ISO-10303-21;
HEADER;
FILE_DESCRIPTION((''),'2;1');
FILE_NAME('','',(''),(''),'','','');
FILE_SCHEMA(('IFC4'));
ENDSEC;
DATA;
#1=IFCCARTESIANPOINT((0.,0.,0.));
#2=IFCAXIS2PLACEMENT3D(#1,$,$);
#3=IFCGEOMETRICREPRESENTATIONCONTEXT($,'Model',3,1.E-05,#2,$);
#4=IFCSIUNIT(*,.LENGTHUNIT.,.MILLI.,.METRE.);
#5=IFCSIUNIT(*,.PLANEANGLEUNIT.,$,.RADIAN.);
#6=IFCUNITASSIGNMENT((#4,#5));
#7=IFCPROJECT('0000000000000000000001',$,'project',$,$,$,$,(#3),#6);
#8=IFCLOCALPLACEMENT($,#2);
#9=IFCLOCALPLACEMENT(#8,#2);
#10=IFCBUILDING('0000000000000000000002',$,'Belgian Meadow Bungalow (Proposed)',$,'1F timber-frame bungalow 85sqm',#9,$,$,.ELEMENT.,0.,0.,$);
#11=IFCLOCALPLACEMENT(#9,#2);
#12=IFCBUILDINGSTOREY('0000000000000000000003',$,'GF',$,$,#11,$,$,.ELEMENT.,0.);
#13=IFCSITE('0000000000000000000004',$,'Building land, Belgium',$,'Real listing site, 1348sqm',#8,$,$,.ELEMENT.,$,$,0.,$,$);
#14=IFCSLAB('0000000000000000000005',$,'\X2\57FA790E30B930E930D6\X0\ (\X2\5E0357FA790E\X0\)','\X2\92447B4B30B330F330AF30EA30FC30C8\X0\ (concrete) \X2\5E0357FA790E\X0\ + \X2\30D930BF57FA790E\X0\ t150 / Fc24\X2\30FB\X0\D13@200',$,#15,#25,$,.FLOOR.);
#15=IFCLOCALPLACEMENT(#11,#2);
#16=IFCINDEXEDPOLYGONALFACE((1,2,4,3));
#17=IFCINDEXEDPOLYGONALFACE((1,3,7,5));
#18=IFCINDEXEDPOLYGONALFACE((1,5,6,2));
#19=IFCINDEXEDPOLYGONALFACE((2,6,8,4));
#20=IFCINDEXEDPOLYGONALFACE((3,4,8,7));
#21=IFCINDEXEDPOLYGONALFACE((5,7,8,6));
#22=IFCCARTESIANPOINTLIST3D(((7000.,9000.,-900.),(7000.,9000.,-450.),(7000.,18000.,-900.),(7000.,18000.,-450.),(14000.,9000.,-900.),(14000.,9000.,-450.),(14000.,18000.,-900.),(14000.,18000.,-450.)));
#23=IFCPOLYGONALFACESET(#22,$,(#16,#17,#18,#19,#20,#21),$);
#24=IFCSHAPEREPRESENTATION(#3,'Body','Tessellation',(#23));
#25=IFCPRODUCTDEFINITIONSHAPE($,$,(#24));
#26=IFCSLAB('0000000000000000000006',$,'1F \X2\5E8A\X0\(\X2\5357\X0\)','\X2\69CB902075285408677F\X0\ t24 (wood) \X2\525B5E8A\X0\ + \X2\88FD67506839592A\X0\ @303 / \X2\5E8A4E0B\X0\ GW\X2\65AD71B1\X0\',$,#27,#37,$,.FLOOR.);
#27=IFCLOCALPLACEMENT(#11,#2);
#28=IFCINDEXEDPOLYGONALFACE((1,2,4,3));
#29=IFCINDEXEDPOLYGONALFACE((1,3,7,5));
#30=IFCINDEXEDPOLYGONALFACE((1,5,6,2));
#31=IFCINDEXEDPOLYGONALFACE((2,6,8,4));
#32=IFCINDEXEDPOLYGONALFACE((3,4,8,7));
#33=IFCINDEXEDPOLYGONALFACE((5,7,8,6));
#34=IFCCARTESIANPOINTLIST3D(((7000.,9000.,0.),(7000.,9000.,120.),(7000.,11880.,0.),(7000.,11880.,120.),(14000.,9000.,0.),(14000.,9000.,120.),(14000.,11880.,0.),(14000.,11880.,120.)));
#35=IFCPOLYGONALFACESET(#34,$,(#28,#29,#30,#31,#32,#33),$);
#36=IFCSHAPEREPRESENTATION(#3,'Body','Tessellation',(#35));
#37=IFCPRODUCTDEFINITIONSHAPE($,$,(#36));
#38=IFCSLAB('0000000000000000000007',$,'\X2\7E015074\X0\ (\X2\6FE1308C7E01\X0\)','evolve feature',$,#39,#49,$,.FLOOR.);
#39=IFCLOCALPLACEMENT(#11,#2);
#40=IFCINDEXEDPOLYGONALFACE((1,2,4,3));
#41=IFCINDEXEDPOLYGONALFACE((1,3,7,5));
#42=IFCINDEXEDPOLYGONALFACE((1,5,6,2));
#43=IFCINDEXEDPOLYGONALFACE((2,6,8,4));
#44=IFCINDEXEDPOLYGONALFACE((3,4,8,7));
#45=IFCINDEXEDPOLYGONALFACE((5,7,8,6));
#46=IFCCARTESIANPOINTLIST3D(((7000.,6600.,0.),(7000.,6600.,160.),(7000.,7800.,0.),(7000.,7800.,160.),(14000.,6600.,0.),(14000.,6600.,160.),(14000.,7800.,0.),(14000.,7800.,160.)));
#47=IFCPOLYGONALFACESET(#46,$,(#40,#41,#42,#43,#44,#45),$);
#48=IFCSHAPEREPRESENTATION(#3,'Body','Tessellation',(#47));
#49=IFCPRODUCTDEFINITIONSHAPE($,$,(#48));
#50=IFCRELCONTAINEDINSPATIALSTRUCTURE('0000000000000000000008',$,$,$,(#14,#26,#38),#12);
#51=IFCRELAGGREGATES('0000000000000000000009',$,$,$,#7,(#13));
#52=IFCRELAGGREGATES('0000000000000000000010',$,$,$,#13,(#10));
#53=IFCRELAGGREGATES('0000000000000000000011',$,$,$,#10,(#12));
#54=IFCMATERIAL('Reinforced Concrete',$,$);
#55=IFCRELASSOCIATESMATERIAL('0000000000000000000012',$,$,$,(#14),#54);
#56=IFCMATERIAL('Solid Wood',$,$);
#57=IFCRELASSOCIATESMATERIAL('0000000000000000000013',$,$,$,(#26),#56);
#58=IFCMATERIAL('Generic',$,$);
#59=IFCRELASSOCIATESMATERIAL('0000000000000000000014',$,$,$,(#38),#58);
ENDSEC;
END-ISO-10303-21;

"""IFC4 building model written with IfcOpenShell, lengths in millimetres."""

from ifc_helpers import new_model, si_unit, frame, frame_2d, origin, place, context, project, spatial, rectangle, extrude, material, element, save


model = new_model("IFC4")

# Units and contexts
model_context = context("Model", 3, precision=1e-05, world=origin())
ifc_project = project(units=[si_unit("LENGTHUNIT", "METRE", prefix="MILLI"), si_unit("PLANEANGLEUNIT", "RADIAN")], contexts=[model_context])

# Site, building, storey
site_placement = place(None, origin())
site = spatial("IfcSite", under=ifc_project, at=site_placement, Name="Building land, Belgium", ObjectType="Real listing site, 1348sqm", CompositionType="ELEMENT", RefElevation=0.0)
building_placement = place(site_placement, origin())
building = spatial("IfcBuilding", under=site, at=building_placement, Name="Belgian Meadow Bungalow (Proposed)", ObjectType="1F timber-frame bungalow 85sqm", CompositionType="ELEMENT", ElevationOfRefHeight=0.0, ElevationOfTerrain=0.0)
storey_placement = place(building_placement, origin())
storey = spatial("IfcBuildingStorey", under=building, at=storey_placement, Name="GF", CompositionType="ELEMENT", Elevation=0.0)

# Slabs
ifc_material_1 = material(Name="Reinforced Concrete")
slab_1_placement = place(storey_placement, frame((3500.0, 4500.0, -450.0)))
element("IfcSlab", 1, at=slab_1_placement, inside=storey, material=ifc_material_1, Name="基礎スラブ (布基礎)", Description="鉄筋コンクリート (concrete) 布基礎 + ベタ基礎 t150 / Fc24・D13@200", PredefinedType="FLOOR", context=model_context, shape_type="SweptSolid", body=[
    extrude(rectangle(XDim=7000.0, YDim=9000.0, at=frame_2d((3500.0, 4500.0))), frame((3500.0, 4500.0, -450.0)), (0.0, 0.0, 1.0), 450.0),
])
ifc_material_2 = material(Name="Solid Wood")
slab_2_placement = place(storey_placement, frame((3500.0, 4500.0, 0.0)))
element("IfcSlab", 2, at=slab_2_placement, inside=storey, material=ifc_material_2, Name="1F 床(南)", Description="構造用合板 t24 (wood) 剛床 + 製材根太 @303 / 床下 GW断熱", PredefinedType="FLOOR", context=model_context, shape_type="SweptSolid", body=[
    extrude(rectangle(XDim=7000.0, YDim=2880.0, at=frame_2d((3500.0, 1440.0))), frame((3500.0, 4500.0, 0.0)), (0.0, 0.0, 1.0), 120.0),
])
ifc_material_3 = material(Name="Generic")
slab_3_placement = place(storey_placement, frame((3500.0, 3300.0, 0.0)))
element("IfcSlab", 3, at=slab_3_placement, inside=storey, material=ifc_material_3, Name="縁側 (濡れ縁)", Description="evolve feature", PredefinedType="FLOOR", context=model_context, shape_type="SweptSolid", body=[
    extrude(rectangle(XDim=7000.0, YDim=1200.0, at=frame_2d((3500.0, 600.0))), frame((3500.0, 3300.0, 0.0)), (0.0, 0.0, 1.0), 160.0),
])

save(model, "model.ifc")
